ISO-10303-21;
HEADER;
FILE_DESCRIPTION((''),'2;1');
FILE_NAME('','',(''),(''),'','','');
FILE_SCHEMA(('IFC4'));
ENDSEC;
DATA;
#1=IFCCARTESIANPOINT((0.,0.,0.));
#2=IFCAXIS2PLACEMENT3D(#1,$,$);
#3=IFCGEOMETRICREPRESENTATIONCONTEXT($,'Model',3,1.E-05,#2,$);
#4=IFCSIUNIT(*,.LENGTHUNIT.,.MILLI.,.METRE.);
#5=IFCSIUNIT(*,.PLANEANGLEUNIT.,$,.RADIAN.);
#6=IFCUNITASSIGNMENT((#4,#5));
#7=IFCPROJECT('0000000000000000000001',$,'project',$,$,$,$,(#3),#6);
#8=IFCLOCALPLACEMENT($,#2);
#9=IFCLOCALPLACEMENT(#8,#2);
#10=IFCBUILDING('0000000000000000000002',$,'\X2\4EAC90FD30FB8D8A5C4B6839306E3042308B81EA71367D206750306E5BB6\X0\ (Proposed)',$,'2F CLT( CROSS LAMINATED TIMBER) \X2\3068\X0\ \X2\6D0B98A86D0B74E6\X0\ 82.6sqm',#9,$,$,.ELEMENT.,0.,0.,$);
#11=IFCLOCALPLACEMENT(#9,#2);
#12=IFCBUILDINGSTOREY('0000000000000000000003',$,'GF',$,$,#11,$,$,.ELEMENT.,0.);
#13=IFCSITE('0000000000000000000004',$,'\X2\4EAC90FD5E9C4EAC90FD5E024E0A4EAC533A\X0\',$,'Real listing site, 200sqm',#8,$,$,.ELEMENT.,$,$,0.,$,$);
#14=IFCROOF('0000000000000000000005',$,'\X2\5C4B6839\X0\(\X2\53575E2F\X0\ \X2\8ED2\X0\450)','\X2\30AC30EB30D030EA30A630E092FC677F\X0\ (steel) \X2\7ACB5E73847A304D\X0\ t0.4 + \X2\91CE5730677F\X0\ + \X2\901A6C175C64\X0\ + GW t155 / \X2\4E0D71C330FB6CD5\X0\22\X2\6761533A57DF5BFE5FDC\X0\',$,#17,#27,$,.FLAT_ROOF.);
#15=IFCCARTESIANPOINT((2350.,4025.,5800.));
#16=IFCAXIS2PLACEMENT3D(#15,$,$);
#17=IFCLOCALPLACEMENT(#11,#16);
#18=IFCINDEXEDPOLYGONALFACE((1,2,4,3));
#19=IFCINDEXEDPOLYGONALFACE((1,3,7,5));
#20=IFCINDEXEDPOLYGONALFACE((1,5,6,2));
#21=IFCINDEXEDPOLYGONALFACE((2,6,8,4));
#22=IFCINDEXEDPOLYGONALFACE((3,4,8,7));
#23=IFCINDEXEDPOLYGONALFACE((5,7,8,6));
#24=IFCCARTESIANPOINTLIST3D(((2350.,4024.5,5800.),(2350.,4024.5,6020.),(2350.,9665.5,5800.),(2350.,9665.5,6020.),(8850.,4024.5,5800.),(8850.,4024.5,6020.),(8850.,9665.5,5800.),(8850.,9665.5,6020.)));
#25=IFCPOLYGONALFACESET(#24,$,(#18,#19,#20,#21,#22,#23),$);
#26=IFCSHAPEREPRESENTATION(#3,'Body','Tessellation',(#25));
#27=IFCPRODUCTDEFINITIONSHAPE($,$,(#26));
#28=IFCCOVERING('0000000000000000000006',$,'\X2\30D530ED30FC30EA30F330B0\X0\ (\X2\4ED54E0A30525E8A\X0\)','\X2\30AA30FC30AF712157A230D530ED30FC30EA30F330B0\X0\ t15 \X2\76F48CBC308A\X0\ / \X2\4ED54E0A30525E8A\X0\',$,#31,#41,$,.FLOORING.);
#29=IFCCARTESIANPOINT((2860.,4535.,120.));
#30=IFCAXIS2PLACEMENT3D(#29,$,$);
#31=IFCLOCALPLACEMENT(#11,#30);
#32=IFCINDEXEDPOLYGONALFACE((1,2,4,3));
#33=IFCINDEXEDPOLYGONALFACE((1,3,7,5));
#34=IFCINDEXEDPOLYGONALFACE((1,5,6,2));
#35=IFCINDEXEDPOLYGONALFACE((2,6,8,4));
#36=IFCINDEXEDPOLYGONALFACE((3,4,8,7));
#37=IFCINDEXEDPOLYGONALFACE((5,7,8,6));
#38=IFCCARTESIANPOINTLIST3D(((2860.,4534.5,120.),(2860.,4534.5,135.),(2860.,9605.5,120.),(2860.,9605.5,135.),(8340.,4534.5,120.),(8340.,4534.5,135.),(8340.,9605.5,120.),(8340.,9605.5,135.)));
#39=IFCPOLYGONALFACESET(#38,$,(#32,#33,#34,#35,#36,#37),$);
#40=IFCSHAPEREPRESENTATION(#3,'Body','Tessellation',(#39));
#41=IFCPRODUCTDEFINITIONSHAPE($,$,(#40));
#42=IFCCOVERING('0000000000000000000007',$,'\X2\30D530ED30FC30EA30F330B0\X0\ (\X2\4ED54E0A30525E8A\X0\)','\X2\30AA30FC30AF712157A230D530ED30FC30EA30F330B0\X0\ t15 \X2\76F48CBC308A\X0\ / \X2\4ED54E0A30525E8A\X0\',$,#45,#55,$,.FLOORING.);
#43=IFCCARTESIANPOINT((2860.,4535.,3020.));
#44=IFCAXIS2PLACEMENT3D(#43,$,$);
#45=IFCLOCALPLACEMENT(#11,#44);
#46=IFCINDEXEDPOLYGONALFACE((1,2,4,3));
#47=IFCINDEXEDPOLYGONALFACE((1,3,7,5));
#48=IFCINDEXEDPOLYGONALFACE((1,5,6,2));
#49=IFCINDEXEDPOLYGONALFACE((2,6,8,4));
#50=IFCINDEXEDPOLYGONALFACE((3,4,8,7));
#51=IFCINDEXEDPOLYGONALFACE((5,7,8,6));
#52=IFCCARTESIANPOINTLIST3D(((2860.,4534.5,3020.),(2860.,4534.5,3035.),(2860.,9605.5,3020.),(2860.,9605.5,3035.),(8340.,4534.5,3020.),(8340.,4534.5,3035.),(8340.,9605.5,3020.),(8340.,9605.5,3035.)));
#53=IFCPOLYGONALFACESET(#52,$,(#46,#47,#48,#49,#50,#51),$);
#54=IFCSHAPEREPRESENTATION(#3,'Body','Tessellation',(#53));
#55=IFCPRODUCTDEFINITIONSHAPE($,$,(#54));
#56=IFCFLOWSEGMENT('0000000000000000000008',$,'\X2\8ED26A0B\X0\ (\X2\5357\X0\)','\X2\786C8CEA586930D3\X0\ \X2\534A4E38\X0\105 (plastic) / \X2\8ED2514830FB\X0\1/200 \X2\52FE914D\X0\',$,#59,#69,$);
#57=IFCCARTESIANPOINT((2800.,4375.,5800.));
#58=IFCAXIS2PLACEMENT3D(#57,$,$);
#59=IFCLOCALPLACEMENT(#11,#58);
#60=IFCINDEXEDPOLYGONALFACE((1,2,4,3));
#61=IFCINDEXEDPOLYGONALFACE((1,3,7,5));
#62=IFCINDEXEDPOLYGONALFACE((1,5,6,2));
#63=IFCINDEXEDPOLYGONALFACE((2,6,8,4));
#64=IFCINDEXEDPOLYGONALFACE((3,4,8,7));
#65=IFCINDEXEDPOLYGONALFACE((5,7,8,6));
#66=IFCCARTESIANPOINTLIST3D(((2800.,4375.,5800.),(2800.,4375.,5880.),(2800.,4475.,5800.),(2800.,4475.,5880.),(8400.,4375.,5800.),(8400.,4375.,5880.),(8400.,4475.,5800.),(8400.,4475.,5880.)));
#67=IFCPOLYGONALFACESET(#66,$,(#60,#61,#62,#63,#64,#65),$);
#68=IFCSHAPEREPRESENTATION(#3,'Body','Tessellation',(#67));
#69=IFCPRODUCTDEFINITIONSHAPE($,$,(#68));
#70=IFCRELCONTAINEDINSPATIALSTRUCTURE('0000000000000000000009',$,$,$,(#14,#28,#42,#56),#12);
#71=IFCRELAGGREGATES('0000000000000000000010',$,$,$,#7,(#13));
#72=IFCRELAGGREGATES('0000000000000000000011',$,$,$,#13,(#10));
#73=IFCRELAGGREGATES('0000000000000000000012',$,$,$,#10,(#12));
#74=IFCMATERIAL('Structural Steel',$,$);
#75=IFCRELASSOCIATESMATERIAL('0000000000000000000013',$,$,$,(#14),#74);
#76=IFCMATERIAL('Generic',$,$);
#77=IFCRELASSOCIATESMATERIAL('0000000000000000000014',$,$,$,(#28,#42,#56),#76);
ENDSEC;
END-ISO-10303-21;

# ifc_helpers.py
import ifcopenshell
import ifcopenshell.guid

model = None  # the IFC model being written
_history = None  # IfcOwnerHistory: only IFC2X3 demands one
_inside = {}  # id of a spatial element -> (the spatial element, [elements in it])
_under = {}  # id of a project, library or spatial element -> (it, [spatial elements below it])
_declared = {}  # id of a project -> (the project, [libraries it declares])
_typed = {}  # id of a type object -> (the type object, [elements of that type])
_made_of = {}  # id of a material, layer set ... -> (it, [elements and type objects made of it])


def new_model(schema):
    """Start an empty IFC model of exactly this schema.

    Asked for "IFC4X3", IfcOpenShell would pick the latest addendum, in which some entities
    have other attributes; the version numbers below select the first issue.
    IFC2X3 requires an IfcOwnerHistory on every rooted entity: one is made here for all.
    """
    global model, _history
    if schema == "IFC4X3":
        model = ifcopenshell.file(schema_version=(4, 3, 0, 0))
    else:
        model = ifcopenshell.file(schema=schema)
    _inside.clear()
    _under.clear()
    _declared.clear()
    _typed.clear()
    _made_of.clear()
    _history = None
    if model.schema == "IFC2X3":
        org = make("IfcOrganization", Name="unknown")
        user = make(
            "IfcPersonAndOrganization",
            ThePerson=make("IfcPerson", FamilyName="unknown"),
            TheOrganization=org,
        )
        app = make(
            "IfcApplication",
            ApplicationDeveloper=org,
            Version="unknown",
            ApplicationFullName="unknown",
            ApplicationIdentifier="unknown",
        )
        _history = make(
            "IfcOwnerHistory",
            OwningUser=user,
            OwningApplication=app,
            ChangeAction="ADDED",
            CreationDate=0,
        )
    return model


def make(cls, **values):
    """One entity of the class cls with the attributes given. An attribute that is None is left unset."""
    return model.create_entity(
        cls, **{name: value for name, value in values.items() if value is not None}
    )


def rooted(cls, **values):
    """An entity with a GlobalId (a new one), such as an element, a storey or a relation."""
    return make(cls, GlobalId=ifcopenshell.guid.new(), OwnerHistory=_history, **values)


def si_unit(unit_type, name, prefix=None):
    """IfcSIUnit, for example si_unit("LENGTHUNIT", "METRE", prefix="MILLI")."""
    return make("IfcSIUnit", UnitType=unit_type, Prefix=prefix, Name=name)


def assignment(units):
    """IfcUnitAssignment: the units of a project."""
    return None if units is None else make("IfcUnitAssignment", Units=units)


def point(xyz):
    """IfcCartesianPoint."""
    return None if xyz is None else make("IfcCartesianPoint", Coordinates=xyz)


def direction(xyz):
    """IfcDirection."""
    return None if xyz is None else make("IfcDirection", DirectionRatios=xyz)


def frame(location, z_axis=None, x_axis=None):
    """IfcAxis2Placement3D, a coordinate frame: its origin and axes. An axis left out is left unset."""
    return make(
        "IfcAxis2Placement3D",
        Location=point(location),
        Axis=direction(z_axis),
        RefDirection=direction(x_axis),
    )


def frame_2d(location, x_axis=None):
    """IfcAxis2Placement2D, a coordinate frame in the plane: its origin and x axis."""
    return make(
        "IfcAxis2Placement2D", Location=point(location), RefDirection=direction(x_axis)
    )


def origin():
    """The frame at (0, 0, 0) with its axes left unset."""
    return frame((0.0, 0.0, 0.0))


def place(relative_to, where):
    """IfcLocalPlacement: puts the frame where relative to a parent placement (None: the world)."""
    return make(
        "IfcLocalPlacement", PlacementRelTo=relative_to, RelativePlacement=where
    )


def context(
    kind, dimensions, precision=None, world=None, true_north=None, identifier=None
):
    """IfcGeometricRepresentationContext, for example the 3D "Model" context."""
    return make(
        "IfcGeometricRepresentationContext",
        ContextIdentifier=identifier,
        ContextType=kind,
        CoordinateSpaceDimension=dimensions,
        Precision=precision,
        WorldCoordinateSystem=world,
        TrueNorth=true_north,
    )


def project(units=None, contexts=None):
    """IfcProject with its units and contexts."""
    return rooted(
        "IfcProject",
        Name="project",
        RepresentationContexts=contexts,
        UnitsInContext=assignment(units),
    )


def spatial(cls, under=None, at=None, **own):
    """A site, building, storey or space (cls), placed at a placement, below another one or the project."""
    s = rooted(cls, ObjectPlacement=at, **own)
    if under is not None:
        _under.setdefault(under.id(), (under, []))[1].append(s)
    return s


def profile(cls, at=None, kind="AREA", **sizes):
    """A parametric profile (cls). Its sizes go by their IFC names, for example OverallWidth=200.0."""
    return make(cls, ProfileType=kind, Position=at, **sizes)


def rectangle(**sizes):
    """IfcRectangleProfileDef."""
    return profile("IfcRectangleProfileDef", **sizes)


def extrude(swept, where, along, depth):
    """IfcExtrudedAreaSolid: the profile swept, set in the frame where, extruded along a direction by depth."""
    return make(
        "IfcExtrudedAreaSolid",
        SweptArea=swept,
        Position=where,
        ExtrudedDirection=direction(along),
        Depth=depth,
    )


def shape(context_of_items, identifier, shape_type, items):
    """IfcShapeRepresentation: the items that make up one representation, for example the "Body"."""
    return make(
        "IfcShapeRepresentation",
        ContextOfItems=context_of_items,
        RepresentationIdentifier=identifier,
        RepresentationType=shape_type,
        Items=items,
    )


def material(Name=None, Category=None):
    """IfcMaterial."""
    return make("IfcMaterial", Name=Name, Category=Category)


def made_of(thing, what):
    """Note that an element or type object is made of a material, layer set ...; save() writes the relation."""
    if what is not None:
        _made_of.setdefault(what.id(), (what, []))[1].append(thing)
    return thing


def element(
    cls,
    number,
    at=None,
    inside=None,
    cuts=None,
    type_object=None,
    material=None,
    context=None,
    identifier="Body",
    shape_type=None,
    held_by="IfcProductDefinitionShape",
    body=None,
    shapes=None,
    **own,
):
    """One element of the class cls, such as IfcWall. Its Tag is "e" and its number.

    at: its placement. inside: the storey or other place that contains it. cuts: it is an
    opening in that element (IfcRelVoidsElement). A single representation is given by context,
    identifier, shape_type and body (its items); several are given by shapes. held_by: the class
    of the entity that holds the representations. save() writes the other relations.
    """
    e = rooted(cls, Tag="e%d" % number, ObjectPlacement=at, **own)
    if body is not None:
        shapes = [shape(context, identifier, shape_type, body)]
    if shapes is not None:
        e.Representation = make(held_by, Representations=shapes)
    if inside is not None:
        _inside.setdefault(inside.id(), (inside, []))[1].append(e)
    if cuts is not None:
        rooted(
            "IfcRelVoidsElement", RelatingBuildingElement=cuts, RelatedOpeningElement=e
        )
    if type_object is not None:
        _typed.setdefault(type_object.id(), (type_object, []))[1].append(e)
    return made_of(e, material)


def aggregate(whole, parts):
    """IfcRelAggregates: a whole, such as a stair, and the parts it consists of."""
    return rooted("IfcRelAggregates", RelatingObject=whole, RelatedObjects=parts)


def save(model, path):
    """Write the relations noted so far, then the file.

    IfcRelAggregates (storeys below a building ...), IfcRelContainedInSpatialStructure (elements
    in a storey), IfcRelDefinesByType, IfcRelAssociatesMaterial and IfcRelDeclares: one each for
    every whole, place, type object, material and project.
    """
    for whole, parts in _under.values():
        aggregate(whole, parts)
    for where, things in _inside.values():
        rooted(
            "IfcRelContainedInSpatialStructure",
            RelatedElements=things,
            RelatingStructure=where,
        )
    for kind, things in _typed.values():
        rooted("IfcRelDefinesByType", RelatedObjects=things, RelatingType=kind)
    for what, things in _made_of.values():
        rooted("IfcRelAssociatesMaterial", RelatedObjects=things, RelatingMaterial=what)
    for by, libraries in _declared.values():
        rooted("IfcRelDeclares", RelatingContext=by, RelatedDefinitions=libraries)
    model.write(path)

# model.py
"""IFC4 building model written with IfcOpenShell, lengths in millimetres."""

from ifc_helpers import new_model, si_unit, frame, frame_2d, origin, place, context, project, spatial, rectangle, extrude, material, element, save


model = new_model("IFC4")

# Units and contexts
model_context = context("Model", 3, precision=1e-05, world=origin())
ifc_project = project(units=[si_unit("LENGTHUNIT", "METRE", prefix="MILLI"), si_unit("PLANEANGLEUNIT", "RADIAN")], contexts=[model_context])

# Site, building, storey
site_placement = place(None, origin())
site = spatial("IfcSite", under=ifc_project, at=site_placement, Name="京都府京都市上京区", ObjectType="Real listing site, 200sqm", CompositionType="ELEMENT", RefElevation=0.0)
building_placement = place(site_placement, origin())
building = spatial("IfcBuilding", under=site, at=building_placement, Name="京都・越屋根のある自然素材の家 (Proposed)", ObjectType="2F CLT( CROSS LAMINATED TIMBER) と 洋風洋瓦 82.6sqm", CompositionType="ELEMENT", ElevationOfRefHeight=0.0, ElevationOfTerrain=0.0)
storey_placement = place(building_placement, origin())
storey = spatial("IfcBuildingStorey", under=building, at=storey_placement, Name="GF", CompositionType="ELEMENT", Elevation=0.0)

# Roof
ifc_material_1 = material(Name="Structural Steel")
for number, where, name in (
    (1, (2350.0, 4025.0, 5800.0), "屋根(南帯 軒450)"),
):
    element("IfcRoof", number, at=place(storey_placement, frame(where)), inside=storey, material=ifc_material_1, Name=name, Description="ガルバリウム鋼板 (steel) 立平葺き t0.4 + 野地板 + 通気層 + GW t155 / 不燃・法22条区域対応", PredefinedType="FLAT_ROOF", context=model_context, shape_type="SweptSolid", body=[
        extrude(rectangle(XDim=6500.0, YDim=5641.0, at=frame_2d((3250.0, 2820.0))), frame((2350.0, 4025.0, 5800.0)), (0.0, 0.0, 1.0), 220.0),
    ])

# Coverings
ifc_material_2 = material(Name="Generic")
covering_1_placement = place(storey_placement, frame((2860.0, 4535.0, 120.0)))
element("IfcCovering", 2, at=covering_1_placement, inside=storey, material=ifc_material_2, Name="フローリング (仕上げ床)", Description="オーク無垢フローリング t15 直貼り / 仕上げ床", PredefinedType="FLOORING", context=model_context, shape_type="SweptSolid", body=[
    extrude(rectangle(XDim=5480.0, YDim=5071.0, at=frame_2d((2740.0, 2535.0))), frame((2860.0, 4535.0, 120.0)), (0.0, 0.0, 1.0), 15.0),
])
covering_2_placement = place(storey_placement, frame((2860.0, 4535.0, 3020.0)))
element("IfcCovering", 3, at=covering_2_placement, inside=storey, material=ifc_material_2, Name="フローリング (仕上げ床)", Description="オーク無垢フローリング t15 直貼り / 仕上げ床", PredefinedType="FLOORING", context=model_context, shape_type="SweptSolid", body=[
    extrude(rectangle(XDim=5480.0, YDim=5071.0, at=frame_2d((2740.0, 2535.0))), frame((2860.0, 4535.0, 3020.0)), (0.0, 0.0, 1.0), 15.0),
])

# Flow segment
flow_segment_placement = place(storey_placement, frame((2800.0, 4375.0, 5800.0)))
element("IfcFlowSegment", 4, at=flow_segment_placement, inside=storey, material=ifc_material_2, Name="軒樋 (南)", Description="硬質塩ビ 半丸105 (plastic) / 軒先・1/200 勾配", context=model_context, shape_type="SweptSolid", body=[
    extrude(rectangle(XDim=5600.0, YDim=100.0, at=frame_2d((2800.0, 50.0))), frame((2800.0, 4375.0, 5800.0)), (0.0, 0.0, 1.0), 80.0),
])

save(model, "model.ifc")
